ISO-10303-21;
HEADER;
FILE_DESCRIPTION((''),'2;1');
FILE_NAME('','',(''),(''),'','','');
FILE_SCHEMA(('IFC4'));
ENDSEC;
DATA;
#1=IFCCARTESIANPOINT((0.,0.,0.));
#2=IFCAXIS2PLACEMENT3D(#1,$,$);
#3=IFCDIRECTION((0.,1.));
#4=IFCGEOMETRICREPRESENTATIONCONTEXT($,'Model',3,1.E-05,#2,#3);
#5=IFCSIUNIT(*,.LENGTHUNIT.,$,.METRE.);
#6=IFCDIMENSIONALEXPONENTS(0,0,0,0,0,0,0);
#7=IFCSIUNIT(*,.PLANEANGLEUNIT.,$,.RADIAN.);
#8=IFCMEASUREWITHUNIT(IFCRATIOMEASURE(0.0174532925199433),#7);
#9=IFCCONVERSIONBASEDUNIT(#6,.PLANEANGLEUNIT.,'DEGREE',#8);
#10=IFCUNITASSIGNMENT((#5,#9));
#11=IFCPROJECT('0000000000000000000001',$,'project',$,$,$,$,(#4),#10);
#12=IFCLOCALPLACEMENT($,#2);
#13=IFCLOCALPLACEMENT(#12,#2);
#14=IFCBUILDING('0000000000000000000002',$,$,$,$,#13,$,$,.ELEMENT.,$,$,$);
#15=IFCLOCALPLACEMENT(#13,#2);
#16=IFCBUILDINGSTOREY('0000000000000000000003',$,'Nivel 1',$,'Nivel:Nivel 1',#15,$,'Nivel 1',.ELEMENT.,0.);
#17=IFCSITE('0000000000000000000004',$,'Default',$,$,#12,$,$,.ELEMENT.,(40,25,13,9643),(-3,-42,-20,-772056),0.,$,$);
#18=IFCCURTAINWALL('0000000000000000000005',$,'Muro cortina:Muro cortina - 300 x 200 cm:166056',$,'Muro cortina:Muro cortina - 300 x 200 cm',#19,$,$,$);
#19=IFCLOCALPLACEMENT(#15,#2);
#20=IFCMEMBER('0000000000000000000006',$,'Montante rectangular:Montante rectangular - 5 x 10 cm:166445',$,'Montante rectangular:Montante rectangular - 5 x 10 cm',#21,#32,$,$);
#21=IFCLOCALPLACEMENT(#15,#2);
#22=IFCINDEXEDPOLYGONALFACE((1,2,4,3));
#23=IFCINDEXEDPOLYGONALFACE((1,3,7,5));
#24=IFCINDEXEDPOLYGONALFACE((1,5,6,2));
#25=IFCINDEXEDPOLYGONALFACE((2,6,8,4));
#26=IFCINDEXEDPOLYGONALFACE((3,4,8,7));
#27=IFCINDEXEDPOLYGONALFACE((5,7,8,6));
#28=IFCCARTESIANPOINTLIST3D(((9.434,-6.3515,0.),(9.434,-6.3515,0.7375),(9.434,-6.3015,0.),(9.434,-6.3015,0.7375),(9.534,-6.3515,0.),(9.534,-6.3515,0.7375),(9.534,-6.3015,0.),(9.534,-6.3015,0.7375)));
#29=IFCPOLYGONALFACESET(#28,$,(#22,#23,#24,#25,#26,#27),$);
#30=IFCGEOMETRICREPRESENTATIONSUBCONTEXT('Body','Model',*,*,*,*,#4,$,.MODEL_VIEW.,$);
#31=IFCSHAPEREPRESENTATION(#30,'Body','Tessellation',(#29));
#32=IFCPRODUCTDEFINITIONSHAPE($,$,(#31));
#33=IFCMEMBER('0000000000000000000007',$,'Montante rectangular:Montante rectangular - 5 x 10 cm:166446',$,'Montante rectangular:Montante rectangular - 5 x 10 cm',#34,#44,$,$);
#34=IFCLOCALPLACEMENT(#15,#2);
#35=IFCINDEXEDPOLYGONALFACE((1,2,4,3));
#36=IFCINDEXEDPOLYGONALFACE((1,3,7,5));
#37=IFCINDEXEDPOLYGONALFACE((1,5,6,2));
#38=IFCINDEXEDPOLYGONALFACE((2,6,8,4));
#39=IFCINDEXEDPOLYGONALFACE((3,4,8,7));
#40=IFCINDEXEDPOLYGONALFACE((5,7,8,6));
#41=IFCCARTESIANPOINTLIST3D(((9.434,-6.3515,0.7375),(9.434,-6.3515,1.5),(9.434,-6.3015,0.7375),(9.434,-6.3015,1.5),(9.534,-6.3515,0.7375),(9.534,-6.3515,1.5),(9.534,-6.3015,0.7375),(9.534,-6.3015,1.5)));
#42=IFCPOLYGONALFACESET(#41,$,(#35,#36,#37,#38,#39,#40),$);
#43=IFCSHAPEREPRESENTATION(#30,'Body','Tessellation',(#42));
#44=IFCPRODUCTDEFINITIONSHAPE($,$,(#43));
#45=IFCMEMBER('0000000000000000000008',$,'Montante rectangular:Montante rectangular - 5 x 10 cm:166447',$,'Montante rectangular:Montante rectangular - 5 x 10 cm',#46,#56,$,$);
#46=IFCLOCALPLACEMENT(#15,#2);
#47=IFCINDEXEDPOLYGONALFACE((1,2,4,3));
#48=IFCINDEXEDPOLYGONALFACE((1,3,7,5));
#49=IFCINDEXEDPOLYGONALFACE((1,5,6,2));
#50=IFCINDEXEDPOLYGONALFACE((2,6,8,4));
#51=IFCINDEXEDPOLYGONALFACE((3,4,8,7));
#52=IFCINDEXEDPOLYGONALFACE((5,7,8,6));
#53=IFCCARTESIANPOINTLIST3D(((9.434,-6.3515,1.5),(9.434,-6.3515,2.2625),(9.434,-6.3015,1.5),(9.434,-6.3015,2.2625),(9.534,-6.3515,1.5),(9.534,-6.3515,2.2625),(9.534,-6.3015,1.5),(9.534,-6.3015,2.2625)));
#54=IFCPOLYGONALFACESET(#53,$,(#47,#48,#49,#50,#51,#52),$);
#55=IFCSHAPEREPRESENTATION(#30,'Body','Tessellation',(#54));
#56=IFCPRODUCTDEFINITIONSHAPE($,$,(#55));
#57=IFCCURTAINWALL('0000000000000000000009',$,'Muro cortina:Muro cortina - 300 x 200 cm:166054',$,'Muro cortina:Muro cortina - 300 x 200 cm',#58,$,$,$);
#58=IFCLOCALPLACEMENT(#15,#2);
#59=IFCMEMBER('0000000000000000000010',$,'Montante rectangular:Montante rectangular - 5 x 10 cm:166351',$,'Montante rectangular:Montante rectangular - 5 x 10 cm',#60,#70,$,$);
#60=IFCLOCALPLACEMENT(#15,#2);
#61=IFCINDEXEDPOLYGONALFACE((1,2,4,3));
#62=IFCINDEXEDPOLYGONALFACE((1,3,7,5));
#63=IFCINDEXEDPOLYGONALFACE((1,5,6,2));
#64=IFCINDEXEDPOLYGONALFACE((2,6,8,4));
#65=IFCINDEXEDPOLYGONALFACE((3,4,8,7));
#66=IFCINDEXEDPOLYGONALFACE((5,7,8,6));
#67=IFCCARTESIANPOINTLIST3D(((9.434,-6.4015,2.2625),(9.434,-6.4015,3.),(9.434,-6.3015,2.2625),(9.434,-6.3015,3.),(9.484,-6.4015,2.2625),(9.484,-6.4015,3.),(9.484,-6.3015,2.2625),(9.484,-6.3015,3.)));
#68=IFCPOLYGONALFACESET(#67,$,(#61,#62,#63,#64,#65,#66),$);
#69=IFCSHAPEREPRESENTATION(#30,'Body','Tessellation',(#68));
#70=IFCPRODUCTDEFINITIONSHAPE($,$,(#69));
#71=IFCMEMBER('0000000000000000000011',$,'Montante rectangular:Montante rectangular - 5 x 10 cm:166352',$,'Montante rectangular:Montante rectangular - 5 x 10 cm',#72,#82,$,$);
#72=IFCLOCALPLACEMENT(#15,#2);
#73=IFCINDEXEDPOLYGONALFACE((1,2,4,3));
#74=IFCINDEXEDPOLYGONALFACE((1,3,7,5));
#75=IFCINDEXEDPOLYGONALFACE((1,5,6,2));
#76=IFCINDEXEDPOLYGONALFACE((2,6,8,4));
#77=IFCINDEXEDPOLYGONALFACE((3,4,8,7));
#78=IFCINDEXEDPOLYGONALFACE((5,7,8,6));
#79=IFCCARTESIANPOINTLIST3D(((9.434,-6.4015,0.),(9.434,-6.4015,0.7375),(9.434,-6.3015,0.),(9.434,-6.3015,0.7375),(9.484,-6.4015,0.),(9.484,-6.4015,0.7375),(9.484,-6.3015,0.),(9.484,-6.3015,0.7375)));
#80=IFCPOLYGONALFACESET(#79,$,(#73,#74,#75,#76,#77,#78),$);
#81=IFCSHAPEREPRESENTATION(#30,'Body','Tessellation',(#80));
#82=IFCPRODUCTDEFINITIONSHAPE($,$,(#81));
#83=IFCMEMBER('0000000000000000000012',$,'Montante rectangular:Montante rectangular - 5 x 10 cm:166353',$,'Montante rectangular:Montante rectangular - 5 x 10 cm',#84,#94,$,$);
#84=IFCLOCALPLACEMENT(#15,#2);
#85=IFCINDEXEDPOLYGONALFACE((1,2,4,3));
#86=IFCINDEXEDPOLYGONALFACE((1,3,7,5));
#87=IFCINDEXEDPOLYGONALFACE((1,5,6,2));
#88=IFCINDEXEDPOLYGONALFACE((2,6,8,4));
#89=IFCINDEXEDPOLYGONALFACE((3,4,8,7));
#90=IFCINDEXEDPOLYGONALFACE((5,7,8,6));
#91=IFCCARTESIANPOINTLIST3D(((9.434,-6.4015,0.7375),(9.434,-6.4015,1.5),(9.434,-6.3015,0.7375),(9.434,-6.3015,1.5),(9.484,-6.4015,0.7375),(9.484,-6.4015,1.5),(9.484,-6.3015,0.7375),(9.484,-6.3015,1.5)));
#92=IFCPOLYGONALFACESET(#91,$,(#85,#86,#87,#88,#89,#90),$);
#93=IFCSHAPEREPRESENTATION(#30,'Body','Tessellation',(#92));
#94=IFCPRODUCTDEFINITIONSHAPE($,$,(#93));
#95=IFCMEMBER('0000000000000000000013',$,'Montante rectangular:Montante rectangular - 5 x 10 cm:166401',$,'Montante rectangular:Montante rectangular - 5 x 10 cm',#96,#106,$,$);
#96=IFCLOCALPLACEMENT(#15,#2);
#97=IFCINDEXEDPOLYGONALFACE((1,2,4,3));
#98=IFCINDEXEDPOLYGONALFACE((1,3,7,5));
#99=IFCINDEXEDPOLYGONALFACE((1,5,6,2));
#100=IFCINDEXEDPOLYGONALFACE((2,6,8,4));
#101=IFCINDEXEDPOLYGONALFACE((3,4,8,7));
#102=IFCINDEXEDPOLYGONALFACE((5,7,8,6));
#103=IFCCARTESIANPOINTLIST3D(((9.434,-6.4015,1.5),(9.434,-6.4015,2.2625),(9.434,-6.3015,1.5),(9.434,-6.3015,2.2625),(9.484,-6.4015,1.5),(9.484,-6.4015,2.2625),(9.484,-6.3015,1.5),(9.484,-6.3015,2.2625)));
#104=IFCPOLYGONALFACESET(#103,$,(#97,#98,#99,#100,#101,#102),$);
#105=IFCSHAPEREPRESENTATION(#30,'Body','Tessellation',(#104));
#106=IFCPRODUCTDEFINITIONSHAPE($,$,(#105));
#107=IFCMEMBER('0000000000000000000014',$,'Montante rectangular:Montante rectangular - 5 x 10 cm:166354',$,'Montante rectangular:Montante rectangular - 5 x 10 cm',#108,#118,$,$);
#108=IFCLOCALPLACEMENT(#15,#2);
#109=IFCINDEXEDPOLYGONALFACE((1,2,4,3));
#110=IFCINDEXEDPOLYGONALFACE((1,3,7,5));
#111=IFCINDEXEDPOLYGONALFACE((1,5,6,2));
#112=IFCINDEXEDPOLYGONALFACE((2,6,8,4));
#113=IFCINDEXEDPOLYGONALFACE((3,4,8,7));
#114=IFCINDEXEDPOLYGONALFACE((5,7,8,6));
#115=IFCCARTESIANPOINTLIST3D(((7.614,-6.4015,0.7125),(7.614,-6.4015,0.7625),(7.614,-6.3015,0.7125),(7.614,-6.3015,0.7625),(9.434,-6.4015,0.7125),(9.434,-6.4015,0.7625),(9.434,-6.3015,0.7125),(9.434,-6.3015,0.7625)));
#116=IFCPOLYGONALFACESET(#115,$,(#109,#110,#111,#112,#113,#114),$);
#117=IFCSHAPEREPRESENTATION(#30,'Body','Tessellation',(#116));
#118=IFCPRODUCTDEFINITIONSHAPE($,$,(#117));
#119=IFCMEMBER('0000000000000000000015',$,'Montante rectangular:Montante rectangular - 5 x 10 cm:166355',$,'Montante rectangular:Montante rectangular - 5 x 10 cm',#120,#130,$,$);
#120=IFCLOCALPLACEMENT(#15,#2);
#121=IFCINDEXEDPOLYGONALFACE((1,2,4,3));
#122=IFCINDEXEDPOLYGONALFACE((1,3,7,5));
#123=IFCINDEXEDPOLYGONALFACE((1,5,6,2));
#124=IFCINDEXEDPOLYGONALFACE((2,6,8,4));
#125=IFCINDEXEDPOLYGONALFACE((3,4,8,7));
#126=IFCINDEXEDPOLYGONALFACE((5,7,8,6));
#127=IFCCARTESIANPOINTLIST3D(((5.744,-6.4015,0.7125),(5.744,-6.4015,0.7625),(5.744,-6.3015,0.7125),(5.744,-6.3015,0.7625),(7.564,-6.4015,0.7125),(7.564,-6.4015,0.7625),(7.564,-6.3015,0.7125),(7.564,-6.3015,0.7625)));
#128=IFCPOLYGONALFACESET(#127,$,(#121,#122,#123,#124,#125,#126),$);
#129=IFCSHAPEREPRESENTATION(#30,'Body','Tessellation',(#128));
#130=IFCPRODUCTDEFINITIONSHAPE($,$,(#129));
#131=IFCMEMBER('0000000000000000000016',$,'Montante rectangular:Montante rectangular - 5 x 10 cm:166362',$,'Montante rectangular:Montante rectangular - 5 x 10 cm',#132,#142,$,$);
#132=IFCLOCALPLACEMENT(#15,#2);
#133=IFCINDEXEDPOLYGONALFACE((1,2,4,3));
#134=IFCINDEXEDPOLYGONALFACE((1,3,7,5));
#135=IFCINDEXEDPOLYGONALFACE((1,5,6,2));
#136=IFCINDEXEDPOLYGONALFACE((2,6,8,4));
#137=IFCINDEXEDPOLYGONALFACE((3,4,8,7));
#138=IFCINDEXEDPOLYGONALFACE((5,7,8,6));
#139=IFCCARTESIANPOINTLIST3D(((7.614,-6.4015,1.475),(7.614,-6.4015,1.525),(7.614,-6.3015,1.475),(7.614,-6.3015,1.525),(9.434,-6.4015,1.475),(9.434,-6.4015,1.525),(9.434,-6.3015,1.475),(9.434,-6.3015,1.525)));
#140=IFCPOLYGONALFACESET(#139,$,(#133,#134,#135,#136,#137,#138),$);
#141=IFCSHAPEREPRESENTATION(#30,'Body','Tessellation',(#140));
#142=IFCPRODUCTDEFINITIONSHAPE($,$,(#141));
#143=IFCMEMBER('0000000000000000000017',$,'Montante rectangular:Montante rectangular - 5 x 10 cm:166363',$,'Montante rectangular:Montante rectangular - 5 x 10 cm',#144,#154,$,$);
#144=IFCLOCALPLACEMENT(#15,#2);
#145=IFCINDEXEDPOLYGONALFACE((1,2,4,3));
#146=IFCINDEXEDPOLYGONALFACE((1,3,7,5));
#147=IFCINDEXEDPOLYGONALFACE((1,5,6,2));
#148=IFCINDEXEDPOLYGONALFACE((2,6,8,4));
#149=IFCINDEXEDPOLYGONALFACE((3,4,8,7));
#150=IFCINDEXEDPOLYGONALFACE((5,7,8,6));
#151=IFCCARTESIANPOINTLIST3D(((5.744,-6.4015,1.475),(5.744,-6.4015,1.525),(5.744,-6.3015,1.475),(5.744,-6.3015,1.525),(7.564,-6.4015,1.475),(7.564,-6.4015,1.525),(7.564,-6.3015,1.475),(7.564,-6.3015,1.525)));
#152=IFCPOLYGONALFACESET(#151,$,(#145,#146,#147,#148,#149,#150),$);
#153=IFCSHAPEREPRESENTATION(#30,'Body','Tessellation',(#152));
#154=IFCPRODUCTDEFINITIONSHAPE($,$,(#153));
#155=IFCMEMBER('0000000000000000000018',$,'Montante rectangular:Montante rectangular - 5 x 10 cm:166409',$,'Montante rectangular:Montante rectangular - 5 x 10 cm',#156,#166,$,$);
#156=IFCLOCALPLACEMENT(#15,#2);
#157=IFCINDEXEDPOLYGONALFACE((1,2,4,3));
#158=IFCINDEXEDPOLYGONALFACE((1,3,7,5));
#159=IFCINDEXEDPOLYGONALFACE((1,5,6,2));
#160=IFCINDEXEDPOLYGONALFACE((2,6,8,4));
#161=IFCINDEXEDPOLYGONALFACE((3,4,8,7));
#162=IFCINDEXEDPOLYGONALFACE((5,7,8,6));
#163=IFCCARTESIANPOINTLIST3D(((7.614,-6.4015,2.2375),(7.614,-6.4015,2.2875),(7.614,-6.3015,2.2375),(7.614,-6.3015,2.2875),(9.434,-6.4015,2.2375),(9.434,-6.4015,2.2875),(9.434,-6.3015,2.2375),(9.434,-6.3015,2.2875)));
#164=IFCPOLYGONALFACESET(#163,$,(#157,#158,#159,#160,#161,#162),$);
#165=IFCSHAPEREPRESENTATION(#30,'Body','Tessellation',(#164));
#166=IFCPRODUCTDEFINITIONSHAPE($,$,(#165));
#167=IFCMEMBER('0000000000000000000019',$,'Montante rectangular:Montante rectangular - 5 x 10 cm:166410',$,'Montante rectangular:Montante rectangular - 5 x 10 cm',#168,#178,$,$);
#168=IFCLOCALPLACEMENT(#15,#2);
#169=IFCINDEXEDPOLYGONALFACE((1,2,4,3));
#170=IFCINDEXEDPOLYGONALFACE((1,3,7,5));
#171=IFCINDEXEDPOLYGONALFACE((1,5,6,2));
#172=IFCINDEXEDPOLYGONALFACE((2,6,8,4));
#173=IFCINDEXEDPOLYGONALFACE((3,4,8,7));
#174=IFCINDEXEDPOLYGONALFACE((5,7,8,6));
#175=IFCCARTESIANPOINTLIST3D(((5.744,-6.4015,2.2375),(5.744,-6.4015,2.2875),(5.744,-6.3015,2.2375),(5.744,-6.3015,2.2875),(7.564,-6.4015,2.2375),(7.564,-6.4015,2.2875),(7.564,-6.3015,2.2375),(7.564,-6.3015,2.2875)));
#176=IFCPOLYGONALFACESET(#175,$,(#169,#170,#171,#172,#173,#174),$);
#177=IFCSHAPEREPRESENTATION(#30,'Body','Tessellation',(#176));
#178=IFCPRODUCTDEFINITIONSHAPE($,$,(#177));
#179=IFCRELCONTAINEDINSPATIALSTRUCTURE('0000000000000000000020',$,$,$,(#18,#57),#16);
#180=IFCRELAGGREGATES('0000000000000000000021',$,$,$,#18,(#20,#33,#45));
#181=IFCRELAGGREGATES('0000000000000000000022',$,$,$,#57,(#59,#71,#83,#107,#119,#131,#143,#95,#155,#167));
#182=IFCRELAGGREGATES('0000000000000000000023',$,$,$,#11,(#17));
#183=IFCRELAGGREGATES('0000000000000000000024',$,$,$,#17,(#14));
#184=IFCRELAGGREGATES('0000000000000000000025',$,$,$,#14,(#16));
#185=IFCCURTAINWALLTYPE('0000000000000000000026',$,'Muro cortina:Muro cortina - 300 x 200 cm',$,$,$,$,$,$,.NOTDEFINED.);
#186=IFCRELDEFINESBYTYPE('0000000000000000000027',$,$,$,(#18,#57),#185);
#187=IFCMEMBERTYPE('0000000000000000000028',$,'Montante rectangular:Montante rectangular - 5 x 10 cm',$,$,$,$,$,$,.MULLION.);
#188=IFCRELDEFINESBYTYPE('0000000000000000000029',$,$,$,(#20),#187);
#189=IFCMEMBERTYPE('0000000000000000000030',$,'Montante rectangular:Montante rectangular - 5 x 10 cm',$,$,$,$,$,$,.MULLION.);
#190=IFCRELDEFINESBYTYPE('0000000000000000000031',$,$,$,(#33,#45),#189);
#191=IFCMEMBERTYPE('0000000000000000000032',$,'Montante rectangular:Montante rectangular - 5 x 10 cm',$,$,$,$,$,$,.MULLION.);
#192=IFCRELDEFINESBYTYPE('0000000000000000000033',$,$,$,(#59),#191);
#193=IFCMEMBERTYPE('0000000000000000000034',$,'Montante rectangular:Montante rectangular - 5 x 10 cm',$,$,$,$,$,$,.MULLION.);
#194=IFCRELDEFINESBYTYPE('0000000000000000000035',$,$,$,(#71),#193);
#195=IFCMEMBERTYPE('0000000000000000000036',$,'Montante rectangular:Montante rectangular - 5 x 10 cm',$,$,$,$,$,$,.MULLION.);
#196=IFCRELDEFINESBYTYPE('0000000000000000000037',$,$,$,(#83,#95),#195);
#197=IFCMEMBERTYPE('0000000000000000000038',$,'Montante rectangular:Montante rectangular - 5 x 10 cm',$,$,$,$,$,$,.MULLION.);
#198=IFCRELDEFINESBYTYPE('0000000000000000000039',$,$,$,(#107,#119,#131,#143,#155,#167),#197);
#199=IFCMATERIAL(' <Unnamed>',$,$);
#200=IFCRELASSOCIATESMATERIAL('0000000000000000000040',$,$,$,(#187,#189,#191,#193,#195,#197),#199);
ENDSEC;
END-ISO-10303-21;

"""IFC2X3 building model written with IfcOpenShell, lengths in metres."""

from ifc_helpers import new_model, entity, si_unit, converted_unit, direction, frame, origin, origin_2d_with_axis, place, context, subcontext, project, spatial, rectangle, extrude, source, transform, mapped, material, type_object, type_shapes, element, aggregate, save


model = new_model("IFC2X3")

# Units and contexts
model_context = context("Model", 3, precision=1e-05, world=origin(), true_north=direction((0.0, 1.0)))
body_context = subcontext(model_context, "Body", "Model", "MODEL_VIEW")
ifc_project = project(units=[si_unit("LENGTHUNIT", "METRE"), converted_unit("PLANEANGLEUNIT", "DEGREE", entity("IfcRatioMeasure", 0.0174532925199433), si_unit("PLANEANGLEUNIT", "RADIAN"), dimensions=[0, 0, 0, 0, 0, 0, 0])], contexts=[model_context])

# Site, building, storey
site_placement = place(None, origin())
site = spatial("IfcSite", under=ifc_project, at=site_placement, Name="Default", CompositionType="ELEMENT", RefLatitude=(40, 25, 13, 9643), RefLongitude=(-3, -42, -20, -772056), RefElevation=0.0)
building_placement = place(site_placement, origin())
building = spatial("IfcBuilding", under=site, at=building_placement, CompositionType="ELEMENT")
storey_placement = place(building_placement, origin())
storey = spatial("IfcBuildingStorey", under=building, at=storey_placement, Name="Nivel 1", ObjectType="Nivel:Nivel 1", LongName="Nivel 1", CompositionType="ELEMENT", Elevation=0.0)

# Curtain walls, members
curtain_wall_type = type_object("IfcCurtainWallType", Name="Muro cortina:Muro cortina - 300 x 200 cm", PredefinedType="NOTDEFINED")
curtain_wall_1_placement = place(storey_placement, origin())
curtain_wall_1 = element("IfcCurtainWall", 1, at=curtain_wall_1_placement, inside=storey, type_object=curtain_wall_type, Name="Muro cortina:Muro cortina - 300 x 200 cm:166056", ObjectType="Muro cortina:Muro cortina - 300 x 200 cm")
ifc_material_1 = material(Name=" <Unnamed>")
member_type_1 = type_object("IfcMemberType", Name="Montante rectangular:Montante rectangular - 5 x 10 cm", PredefinedType="MULLION", material=ifc_material_1)
shared_shape_1 = source(origin(), body_context, "Body", "SweptSolid", [
    extrude(rectangle(XDim=0.1, YDim=0.05, at=origin_2d_with_axis()), frame((-0.025, 0.0, -0.7375), z_axis=(0.0, 0.0, 1.0), x_axis=(0.0, -1.0, 0.0)), (0.0, 0.0, 1.0), 0.7375),
])
type_shapes(member_type_1, [shared_shape_1])
member_1_placement = place(storey_placement, frame((9.484, -6.3515, 0.0), z_axis=(0.0, 0.0, -1.0), x_axis=(0.0, -1.0, 0.0)))
member_1 = element("IfcMember", 2, at=member_1_placement, type_object=member_type_1, Name="Montante rectangular:Montante rectangular - 5 x 10 cm:166445", ObjectType="Montante rectangular:Montante rectangular - 5 x 10 cm", context=body_context, shape_type="MappedRepresentation", body=[
    mapped(shared_shape_1, transform((0.0, 0.0, 0.0), scale=1.0)),
])
member_type_2 = type_object("IfcMemberType", Name="Montante rectangular:Montante rectangular - 5 x 10 cm", PredefinedType="MULLION", material=ifc_material_1)
shared_shape_2 = source(origin(), body_context, "Body", "SweptSolid", [
    extrude(rectangle(XDim=0.1, YDim=0.05, at=origin_2d_with_axis()), frame((-0.025, 0.0, -0.7625), z_axis=(0.0, 0.0, 1.0), x_axis=(0.0, -1.0, 0.0)), (0.0, 0.0, 1.0), 0.7625),
])
type_shapes(member_type_2, [shared_shape_2])
member_2_placement = place(storey_placement, frame((9.484, -6.3515, 0.7375), z_axis=(0.0, 0.0, -1.0), x_axis=(0.0, -1.0, 0.0)))
member_2 = element("IfcMember", 3, at=member_2_placement, type_object=member_type_2, Name="Montante rectangular:Montante rectangular - 5 x 10 cm:166446", ObjectType="Montante rectangular:Montante rectangular - 5 x 10 cm", context=body_context, shape_type="MappedRepresentation", body=[
    mapped(shared_shape_2, transform((0.0, 0.0, 0.0), scale=1.0)),
])
member_3_placement = place(storey_placement, frame((9.484, -6.3515, 1.5), z_axis=(0.0, 0.0, -1.0), x_axis=(0.0, -1.0, 0.0)))
member_3 = element("IfcMember", 4, at=member_3_placement, type_object=member_type_2, Name="Montante rectangular:Montante rectangular - 5 x 10 cm:166447", ObjectType="Montante rectangular:Montante rectangular - 5 x 10 cm", context=body_context, shape_type="MappedRepresentation", body=[
    mapped(shared_shape_2, transform((0.0, 0.0, 0.0), scale=1.0)),
])
curtain_wall_2_placement = place(storey_placement, origin())
curtain_wall_2 = element("IfcCurtainWall", 5, at=curtain_wall_2_placement, inside=storey, type_object=curtain_wall_type, Name="Muro cortina:Muro cortina - 300 x 200 cm:166054", ObjectType="Muro cortina:Muro cortina - 300 x 200 cm")
member_type_3 = type_object("IfcMemberType", Name="Montante rectangular:Montante rectangular - 5 x 10 cm", PredefinedType="MULLION", material=ifc_material_1)
shared_shape_3 = source(origin(), body_context, "Body", "SweptSolid", [
    extrude(rectangle(XDim=0.1, YDim=0.05, at=origin_2d_with_axis()), frame((-0.025, 0.0, -0.7375), z_axis=(0.0, 0.0, 1.0), x_axis=(0.0, -1.0, 0.0)), (0.0, 0.0, 1.0), 0.7375),
])
type_shapes(member_type_3, [shared_shape_3])
member_4_placement = place(storey_placement, frame((9.484, -6.3515, 3.0)))
member_4 = element("IfcMember", 6, at=member_4_placement, type_object=member_type_3, Name="Montante rectangular:Montante rectangular - 5 x 10 cm:166351", ObjectType="Montante rectangular:Montante rectangular - 5 x 10 cm", context=body_context, shape_type="MappedRepresentation", body=[
    mapped(shared_shape_3, transform((0.0, 0.0, 0.0), scale=1.0)),
])
member_type_4 = type_object("IfcMemberType", Name="Montante rectangular:Montante rectangular - 5 x 10 cm", PredefinedType="MULLION", material=ifc_material_1)
shared_shape_4 = source(origin(), body_context, "Body", "SweptSolid", [
    extrude(rectangle(XDim=0.1, YDim=0.05, at=origin_2d_with_axis()), frame((-0.025, 0.0, -0.7375), z_axis=(0.0, 0.0, 1.0), x_axis=(0.0, -1.0, 0.0)), (0.0, 0.0, 1.0), 0.7375),
])
type_shapes(member_type_4, [shared_shape_4])
member_5_placement = place(storey_placement, frame((9.484, -6.3515, 0.7375)))
member_5 = element("IfcMember", 7, at=member_5_placement, type_object=member_type_4, Name="Montante rectangular:Montante rectangular - 5 x 10 cm:166352", ObjectType="Montante rectangular:Montante rectangular - 5 x 10 cm", context=body_context, shape_type="MappedRepresentation", body=[
    mapped(shared_shape_4, transform((0.0, 0.0, 0.0), scale=1.0)),
])
member_type_5 = type_object("IfcMemberType", Name="Montante rectangular:Montante rectangular - 5 x 10 cm", PredefinedType="MULLION", material=ifc_material_1)
shared_shape_5 = source(origin(), body_context, "Body", "SweptSolid", [
    extrude(rectangle(XDim=0.1, YDim=0.05, at=origin_2d_with_axis()), frame((-0.025, 0.0, -0.7625), z_axis=(0.0, 0.0, 1.0), x_axis=(0.0, -1.0, 0.0)), (0.0, 0.0, 1.0), 0.7625),
])
type_shapes(member_type_5, [shared_shape_5])
member_6_placement = place(storey_placement, frame((9.484, -6.3515, 1.5)))
member_6 = element("IfcMember", 8, at=member_6_placement, type_object=member_type_5, Name="Montante rectangular:Montante rectangular - 5 x 10 cm:166353", ObjectType="Montante rectangular:Montante rectangular - 5 x 10 cm", context=body_context, shape_type="MappedRepresentation", body=[
    mapped(shared_shape_5, transform((0.0, 0.0, 0.0), scale=1.0)),
])
member_7_placement = place(storey_placement, frame((9.484, -6.3515, 2.2625)))
member_7 = element("IfcMember", 9, at=member_7_placement, type_object=member_type_5, Name="Montante rectangular:Montante rectangular - 5 x 10 cm:166401", ObjectType="Montante rectangular:Montante rectangular - 5 x 10 cm", context=body_context, shape_type="MappedRepresentation", body=[
    mapped(shared_shape_5, transform((0.0, 0.0, 0.0), scale=1.0)),
])
member_type_6 = type_object("IfcMemberType", Name="Montante rectangular:Montante rectangular - 5 x 10 cm", PredefinedType="MULLION", material=ifc_material_1)
shared_shape_6 = source(origin(), body_context, "Body", "SweptSolid", [
    extrude(rectangle(XDim=0.1, YDim=0.05, at=origin_2d_with_axis()), frame((0.0, 0.0, -1.82), z_axis=(0.0, 0.0, 1.0), x_axis=(0.0, -1.0, 0.0)), (0.0, 0.0, 1.0), 1.82),
])
type_shapes(member_type_6, [shared_shape_6])
member_8_placement = place(storey_placement, frame((7.614, -6.3515, 0.7375), z_axis=(-1.0, 0.0, 0.0), x_axis=(0.0, 0.0, 1.0)))
member_8 = element("IfcMember", 10, at=member_8_placement, type_object=member_type_6, Name="Montante rectangular:Montante rectangular - 5 x 10 cm:166354", ObjectType="Montante rectangular:Montante rectangular - 5 x 10 cm", context=body_context, shape_type="MappedRepresentation", body=[
    mapped(shared_shape_6, transform((0.0, 0.0, 0.0), scale=1.0)),
])
member_9_placement = place(storey_placement, frame((5.744, -6.3515, 0.7375), z_axis=(-1.0, 0.0, 0.0), x_axis=(0.0, 0.0, 1.0)))
member_9 = element("IfcMember", 11, at=member_9_placement, type_object=member_type_6, Name="Montante rectangular:Montante rectangular - 5 x 10 cm:166355", ObjectType="Montante rectangular:Montante rectangular - 5 x 10 cm", context=body_context, shape_type="MappedRepresentation", body=[
    mapped(shared_shape_6, transform((0.0, 0.0, 0.0), scale=1.0)),
])
member_10_placement = place(storey_placement, frame((7.614, -6.3515, 1.5), z_axis=(-1.0, 0.0, 0.0), x_axis=(0.0, 0.0, 1.0)))
member_10 = element("IfcMember", 12, at=member_10_placement, type_object=member_type_6, Name="Montante rectangular:Montante rectangular - 5 x 10 cm:166362", ObjectType="Montante rectangular:Montante rectangular - 5 x 10 cm", context=body_context, shape_type="MappedRepresentation", body=[
    mapped(shared_shape_6, transform((0.0, 0.0, 0.0), scale=1.0)),
])
member_11_placement = place(storey_placement, frame((5.744, -6.3515, 1.5), z_axis=(-1.0, 0.0, 0.0), x_axis=(0.0, 0.0, 1.0)))
member_11 = element("IfcMember", 13, at=member_11_placement, type_object=member_type_6, Name="Montante rectangular:Montante rectangular - 5 x 10 cm:166363", ObjectType="Montante rectangular:Montante rectangular - 5 x 10 cm", context=body_context, shape_type="MappedRepresentation", body=[
    mapped(shared_shape_6, transform((0.0, 0.0, 0.0), scale=1.0)),
])
member_12_placement = place(storey_placement, frame((7.614, -6.3515, 2.2625), z_axis=(-1.0, 0.0, 0.0), x_axis=(0.0, 0.0, 1.0)))
member_12 = element("IfcMember", 14, at=member_12_placement, type_object=member_type_6, Name="Montante rectangular:Montante rectangular - 5 x 10 cm:166409", ObjectType="Montante rectangular:Montante rectangular - 5 x 10 cm", context=body_context, shape_type="MappedRepresentation", body=[
    mapped(shared_shape_6, transform((0.0, 0.0, 0.0), scale=1.0)),
])
member_13_placement = place(storey_placement, frame((5.744, -6.3515, 2.2625), z_axis=(-1.0, 0.0, 0.0), x_axis=(0.0, 0.0, 1.0)))
member_13 = element("IfcMember", 15, at=member_13_placement, type_object=member_type_6, Name="Montante rectangular:Montante rectangular - 5 x 10 cm:166410", ObjectType="Montante rectangular:Montante rectangular - 5 x 10 cm", context=body_context, shape_type="MappedRepresentation", body=[
    mapped(shared_shape_6, transform((0.0, 0.0, 0.0), scale=1.0)),
])

aggregate(curtain_wall_1, [member_1, member_2, member_3])

aggregate(curtain_wall_2, [member_4, member_5, member_6, member_8, member_9, member_10, member_11, member_7, member_12, member_13])

save(model, "model.ifc")
